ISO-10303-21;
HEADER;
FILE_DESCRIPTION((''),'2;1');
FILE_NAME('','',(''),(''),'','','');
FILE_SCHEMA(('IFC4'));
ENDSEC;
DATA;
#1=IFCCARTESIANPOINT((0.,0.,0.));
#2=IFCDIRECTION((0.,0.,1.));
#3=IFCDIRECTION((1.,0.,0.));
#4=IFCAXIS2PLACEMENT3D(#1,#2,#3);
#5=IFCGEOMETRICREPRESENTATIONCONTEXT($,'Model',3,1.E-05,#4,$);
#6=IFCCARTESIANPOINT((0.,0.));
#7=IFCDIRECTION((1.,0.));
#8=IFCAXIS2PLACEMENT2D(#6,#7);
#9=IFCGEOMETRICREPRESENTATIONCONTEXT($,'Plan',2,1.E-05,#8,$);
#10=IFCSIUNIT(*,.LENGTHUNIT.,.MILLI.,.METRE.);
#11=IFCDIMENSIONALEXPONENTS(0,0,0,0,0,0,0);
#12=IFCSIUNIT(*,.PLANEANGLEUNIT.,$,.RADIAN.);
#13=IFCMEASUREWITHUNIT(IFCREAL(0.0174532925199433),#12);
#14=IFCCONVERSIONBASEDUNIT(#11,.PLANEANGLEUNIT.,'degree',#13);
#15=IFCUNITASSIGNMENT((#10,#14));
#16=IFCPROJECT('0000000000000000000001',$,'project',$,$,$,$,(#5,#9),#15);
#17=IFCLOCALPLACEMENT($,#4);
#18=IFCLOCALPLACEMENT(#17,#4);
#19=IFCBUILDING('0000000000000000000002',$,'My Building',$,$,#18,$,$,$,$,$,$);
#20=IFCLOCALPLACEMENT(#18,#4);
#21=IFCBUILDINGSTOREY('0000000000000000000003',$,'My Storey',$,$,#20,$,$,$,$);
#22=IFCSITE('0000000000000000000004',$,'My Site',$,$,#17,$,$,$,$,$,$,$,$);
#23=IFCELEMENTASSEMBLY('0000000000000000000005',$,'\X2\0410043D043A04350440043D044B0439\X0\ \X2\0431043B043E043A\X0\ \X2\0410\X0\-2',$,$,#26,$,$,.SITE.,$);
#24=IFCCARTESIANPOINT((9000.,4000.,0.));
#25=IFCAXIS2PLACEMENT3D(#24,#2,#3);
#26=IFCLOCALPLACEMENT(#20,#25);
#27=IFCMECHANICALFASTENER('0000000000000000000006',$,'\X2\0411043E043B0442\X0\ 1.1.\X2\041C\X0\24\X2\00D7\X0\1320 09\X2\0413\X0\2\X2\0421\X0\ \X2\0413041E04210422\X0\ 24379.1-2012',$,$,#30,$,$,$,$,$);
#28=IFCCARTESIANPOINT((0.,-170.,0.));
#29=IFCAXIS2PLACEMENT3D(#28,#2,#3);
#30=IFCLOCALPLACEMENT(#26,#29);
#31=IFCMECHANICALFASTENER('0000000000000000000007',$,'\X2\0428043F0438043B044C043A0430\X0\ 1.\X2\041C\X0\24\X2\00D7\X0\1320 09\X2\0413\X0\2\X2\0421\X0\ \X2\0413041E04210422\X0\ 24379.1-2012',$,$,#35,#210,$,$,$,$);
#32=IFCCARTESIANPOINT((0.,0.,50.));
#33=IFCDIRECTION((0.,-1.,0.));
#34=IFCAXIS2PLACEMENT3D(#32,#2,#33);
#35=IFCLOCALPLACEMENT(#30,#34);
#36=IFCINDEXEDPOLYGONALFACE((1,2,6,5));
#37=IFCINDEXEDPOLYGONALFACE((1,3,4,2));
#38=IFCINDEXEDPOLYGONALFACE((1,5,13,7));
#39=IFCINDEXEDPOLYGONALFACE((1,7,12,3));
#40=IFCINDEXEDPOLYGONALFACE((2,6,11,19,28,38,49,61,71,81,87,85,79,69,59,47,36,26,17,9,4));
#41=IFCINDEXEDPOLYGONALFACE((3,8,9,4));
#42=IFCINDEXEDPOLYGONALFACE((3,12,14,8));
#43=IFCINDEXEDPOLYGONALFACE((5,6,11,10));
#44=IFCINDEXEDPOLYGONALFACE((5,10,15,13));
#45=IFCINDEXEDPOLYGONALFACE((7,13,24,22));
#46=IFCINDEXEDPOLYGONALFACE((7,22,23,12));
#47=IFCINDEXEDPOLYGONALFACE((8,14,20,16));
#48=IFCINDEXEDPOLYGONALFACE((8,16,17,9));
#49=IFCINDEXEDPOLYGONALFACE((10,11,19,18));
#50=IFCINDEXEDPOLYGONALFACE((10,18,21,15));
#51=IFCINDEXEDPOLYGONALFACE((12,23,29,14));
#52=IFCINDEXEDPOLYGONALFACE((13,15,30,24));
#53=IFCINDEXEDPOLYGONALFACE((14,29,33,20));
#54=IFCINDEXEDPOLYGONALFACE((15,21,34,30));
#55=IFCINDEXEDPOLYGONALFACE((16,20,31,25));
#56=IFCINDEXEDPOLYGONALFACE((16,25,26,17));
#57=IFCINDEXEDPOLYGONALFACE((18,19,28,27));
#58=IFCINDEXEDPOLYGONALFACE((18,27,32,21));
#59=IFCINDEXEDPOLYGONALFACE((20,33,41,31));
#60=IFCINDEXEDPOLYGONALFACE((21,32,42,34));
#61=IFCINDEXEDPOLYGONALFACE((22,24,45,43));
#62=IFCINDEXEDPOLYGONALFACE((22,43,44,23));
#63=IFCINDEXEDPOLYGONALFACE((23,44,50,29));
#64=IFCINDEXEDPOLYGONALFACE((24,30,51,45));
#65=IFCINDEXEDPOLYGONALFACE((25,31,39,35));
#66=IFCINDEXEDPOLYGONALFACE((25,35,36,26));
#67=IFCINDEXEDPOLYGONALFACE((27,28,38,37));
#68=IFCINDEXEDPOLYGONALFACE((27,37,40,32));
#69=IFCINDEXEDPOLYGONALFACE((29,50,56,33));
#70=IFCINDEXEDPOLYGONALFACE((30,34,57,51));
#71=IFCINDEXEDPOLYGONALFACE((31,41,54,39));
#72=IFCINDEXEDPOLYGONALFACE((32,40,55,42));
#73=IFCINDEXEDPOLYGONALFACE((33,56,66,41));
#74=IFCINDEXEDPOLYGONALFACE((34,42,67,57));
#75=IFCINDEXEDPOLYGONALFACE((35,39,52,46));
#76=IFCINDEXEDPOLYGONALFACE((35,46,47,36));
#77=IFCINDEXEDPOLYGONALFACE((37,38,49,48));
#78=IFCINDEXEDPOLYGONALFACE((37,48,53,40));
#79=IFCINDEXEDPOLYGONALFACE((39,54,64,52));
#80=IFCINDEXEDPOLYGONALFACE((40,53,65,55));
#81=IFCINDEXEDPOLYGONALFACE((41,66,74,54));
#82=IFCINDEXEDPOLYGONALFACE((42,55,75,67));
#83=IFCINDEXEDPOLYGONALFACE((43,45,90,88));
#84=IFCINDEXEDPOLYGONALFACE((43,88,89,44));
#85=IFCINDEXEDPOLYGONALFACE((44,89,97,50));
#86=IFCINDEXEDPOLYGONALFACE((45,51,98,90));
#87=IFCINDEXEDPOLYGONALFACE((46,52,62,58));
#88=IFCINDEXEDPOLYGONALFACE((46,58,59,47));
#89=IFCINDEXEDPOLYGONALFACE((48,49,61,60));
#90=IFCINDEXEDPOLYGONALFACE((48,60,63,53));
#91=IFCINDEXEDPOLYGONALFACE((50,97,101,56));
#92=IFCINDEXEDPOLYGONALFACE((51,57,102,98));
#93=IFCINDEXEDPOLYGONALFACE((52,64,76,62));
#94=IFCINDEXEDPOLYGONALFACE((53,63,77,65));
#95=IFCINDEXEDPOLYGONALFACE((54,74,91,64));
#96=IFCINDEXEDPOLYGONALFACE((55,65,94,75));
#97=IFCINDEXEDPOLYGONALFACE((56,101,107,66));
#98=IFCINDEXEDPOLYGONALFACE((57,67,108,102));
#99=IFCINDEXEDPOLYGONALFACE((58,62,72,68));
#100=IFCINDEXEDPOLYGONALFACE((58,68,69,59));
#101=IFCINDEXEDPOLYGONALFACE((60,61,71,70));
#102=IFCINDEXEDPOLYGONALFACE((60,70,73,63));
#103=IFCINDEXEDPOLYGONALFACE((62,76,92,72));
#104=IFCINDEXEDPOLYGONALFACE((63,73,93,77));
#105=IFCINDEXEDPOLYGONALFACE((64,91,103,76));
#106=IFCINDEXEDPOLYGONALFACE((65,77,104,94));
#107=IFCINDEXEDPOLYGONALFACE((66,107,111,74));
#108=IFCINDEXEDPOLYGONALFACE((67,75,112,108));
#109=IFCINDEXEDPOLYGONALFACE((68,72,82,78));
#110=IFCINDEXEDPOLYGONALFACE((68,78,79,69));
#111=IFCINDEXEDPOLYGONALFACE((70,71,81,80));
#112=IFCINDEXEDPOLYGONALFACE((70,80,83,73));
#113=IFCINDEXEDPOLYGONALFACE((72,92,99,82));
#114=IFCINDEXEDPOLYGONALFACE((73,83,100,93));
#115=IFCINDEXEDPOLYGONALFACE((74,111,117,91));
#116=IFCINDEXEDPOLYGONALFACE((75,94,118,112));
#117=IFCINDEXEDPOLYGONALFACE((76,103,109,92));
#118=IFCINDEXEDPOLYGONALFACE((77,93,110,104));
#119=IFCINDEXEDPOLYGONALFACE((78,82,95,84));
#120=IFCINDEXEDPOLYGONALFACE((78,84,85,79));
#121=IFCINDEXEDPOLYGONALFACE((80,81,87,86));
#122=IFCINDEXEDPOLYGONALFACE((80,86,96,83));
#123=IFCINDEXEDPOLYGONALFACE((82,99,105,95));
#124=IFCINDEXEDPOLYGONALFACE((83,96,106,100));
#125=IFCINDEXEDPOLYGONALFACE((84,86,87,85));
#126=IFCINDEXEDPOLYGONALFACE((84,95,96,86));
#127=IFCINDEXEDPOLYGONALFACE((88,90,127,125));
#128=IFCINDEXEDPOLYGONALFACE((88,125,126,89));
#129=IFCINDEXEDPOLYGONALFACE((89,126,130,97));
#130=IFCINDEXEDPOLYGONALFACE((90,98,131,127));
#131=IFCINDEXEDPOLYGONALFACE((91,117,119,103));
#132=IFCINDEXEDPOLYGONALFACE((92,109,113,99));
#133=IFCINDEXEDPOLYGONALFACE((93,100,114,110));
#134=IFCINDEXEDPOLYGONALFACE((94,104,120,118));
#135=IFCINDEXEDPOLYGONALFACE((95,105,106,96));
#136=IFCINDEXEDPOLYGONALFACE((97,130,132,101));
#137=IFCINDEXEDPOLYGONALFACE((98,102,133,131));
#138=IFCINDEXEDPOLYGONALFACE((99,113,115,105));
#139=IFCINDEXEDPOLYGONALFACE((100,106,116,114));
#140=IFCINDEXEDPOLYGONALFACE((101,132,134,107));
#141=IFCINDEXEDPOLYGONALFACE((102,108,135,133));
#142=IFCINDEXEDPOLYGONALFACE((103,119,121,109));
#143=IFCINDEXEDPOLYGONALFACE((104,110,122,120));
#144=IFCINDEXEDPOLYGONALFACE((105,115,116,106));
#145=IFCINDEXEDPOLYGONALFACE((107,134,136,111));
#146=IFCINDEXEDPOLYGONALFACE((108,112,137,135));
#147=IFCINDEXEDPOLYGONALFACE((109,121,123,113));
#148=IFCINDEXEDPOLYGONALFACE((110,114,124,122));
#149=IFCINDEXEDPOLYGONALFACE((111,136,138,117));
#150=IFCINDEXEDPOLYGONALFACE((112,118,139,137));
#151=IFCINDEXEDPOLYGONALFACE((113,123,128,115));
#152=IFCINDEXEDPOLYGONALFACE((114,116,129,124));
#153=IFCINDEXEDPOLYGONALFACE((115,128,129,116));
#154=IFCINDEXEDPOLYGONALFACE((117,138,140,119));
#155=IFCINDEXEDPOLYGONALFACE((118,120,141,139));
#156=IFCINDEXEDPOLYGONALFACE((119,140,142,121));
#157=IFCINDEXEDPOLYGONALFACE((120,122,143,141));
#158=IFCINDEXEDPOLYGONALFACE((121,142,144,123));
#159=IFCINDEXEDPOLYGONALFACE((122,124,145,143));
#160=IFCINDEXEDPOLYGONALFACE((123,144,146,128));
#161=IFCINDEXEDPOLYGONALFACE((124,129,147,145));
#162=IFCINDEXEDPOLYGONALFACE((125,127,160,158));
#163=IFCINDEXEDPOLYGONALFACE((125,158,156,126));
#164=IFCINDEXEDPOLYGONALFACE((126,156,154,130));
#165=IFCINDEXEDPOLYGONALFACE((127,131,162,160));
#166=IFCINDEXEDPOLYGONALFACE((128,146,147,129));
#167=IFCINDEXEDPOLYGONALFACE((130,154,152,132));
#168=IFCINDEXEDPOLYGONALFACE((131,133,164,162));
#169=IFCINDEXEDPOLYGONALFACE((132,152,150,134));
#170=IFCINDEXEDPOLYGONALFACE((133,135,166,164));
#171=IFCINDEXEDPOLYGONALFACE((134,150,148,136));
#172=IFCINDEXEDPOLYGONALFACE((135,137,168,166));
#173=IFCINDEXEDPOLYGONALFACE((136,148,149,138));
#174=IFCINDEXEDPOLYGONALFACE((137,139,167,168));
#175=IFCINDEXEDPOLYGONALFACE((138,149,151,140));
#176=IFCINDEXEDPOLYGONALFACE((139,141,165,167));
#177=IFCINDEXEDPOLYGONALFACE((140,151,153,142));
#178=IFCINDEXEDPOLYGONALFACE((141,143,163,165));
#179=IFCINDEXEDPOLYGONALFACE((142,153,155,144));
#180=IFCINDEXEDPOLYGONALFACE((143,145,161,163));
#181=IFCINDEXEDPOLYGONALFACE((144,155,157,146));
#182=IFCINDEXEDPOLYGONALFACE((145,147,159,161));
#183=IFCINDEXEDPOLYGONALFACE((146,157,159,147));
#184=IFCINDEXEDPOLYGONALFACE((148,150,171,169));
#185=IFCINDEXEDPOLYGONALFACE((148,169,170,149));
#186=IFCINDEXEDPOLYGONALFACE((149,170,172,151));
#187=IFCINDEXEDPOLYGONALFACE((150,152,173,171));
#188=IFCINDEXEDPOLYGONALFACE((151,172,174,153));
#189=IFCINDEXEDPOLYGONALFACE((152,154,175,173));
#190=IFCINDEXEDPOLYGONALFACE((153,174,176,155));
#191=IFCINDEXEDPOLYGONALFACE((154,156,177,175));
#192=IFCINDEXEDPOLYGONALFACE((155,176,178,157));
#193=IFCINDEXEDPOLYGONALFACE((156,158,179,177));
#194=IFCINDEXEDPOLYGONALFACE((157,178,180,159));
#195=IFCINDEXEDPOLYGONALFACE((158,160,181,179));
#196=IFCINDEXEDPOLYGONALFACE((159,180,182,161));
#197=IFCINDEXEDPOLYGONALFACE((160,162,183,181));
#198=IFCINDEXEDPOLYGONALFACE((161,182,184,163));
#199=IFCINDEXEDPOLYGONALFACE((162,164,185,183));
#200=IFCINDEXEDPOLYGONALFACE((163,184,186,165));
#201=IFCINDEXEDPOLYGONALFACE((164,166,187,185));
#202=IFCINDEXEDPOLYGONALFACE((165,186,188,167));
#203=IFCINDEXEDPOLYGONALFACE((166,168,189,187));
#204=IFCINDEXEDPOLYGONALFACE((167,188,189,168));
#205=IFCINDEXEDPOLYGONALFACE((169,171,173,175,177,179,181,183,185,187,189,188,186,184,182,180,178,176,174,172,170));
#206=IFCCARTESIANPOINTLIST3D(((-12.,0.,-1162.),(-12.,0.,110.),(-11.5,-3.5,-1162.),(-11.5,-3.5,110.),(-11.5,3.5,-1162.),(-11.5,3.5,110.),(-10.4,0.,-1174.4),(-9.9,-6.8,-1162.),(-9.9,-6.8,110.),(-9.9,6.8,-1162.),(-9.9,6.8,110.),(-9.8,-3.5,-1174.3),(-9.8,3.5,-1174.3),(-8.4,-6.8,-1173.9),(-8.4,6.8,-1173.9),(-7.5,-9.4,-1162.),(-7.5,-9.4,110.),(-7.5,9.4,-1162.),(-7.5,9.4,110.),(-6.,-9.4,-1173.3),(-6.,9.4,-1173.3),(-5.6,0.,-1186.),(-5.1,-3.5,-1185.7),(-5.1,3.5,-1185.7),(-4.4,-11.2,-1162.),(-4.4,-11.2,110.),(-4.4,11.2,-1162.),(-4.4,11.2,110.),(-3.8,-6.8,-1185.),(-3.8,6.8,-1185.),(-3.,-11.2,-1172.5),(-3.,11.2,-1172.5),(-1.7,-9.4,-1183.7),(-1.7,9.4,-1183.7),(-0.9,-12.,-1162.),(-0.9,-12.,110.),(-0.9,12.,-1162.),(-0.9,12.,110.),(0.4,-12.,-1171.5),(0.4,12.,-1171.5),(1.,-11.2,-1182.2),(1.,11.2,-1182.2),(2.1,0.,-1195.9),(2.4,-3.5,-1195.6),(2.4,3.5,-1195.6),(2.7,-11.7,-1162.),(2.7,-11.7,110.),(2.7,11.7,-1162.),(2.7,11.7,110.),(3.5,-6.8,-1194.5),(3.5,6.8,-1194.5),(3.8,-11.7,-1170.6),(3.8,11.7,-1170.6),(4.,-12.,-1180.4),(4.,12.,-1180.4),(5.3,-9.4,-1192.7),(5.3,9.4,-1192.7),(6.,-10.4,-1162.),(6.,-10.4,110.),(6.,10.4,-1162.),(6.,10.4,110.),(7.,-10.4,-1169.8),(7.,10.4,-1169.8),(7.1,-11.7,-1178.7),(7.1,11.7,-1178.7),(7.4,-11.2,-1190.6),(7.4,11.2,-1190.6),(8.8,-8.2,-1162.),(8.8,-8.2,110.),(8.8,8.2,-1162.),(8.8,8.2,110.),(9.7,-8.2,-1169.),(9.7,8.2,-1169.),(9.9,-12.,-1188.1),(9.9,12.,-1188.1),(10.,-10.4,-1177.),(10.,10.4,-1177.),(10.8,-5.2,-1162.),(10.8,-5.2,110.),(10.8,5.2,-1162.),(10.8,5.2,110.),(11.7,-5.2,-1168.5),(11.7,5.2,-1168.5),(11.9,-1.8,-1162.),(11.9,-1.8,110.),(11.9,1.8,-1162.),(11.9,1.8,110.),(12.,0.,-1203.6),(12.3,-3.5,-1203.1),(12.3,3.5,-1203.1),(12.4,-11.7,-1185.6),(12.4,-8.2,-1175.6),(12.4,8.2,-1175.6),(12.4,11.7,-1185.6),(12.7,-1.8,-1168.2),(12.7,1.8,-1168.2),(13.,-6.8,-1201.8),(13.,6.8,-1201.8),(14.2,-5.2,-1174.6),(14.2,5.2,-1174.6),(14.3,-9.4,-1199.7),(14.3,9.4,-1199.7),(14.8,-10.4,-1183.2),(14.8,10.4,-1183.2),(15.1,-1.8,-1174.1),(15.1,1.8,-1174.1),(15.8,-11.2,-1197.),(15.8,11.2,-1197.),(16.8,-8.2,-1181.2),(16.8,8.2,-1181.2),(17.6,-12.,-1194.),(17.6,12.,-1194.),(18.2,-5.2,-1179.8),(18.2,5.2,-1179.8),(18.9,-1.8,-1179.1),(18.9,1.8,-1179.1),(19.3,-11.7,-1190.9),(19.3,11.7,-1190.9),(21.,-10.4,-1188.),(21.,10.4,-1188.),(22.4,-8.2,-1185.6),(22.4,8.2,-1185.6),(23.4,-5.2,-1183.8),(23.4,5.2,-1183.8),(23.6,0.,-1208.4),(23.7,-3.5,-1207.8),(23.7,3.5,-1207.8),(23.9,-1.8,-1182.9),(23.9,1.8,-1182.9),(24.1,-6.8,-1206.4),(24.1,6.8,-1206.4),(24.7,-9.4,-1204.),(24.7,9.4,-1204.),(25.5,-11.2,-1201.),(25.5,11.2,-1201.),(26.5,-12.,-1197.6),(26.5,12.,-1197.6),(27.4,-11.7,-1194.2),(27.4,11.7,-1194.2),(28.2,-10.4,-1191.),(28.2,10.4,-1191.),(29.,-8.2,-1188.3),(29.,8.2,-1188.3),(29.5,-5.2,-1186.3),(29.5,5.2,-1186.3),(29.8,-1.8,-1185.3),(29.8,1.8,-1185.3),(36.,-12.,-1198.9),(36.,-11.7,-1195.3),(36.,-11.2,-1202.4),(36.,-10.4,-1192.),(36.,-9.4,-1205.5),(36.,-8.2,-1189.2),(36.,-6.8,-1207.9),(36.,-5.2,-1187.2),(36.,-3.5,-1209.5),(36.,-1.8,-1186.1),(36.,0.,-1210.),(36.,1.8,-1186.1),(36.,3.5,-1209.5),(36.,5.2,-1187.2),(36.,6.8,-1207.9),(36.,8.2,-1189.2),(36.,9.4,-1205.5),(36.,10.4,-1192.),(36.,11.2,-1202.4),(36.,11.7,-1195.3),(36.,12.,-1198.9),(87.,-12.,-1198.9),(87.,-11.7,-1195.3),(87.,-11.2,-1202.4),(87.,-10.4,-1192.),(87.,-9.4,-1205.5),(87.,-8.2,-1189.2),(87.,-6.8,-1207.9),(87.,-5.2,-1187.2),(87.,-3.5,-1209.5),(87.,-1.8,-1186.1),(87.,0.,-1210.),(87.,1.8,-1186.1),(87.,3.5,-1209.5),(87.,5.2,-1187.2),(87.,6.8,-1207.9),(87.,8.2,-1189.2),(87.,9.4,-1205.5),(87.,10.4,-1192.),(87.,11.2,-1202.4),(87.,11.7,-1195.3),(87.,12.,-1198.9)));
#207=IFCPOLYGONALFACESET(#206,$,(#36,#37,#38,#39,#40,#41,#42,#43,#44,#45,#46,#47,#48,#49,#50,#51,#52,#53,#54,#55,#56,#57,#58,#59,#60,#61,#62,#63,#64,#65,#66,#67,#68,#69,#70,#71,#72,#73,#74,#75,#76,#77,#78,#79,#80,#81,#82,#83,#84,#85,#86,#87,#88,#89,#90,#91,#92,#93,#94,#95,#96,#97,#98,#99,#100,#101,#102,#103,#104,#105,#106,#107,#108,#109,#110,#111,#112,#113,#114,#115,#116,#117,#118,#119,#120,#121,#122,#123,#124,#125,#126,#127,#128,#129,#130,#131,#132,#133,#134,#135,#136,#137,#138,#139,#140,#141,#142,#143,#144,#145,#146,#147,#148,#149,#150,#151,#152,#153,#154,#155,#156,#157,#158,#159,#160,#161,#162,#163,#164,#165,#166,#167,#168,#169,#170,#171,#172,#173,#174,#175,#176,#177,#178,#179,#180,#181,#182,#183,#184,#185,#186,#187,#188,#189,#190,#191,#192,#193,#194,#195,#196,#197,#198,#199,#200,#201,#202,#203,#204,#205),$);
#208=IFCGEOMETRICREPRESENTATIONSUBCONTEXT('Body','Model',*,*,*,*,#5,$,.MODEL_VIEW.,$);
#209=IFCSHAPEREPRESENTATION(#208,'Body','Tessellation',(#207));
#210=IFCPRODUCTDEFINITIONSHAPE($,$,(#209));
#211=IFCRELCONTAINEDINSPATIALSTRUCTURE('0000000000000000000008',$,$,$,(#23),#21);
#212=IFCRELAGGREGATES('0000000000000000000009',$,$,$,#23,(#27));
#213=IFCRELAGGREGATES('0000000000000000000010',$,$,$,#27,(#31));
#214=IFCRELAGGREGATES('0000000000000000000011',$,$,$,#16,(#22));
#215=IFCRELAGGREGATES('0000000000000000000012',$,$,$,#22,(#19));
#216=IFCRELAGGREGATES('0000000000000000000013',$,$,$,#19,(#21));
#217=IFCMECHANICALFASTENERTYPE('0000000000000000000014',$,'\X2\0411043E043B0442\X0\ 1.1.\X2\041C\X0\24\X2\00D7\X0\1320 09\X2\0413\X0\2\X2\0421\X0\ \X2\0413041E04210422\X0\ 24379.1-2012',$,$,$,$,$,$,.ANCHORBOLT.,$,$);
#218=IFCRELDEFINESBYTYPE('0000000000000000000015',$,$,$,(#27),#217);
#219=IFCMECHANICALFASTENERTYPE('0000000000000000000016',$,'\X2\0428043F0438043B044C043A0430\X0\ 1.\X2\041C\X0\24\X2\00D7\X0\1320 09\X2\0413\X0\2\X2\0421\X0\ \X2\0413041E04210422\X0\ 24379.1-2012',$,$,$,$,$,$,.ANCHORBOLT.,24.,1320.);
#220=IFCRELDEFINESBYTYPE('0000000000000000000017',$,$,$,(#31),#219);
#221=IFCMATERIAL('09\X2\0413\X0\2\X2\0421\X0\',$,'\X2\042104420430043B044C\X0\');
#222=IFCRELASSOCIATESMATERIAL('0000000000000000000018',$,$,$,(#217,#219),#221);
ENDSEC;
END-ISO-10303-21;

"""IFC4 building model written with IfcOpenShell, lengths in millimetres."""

from ifc_helpers import new_model, entity, si_unit, converted_unit, frame, origin_with_axes, origin_2d_with_axis, place, context, subcontext, project, spatial, source, transform, mapped, material, type_object, type_shapes, element, aggregate, save


model = new_model("IFC4")

# Units and contexts
model_context = context("Model", 3, precision=1e-05, world=origin_with_axes())
plan_context = context("Plan", 2, precision=1e-05, world=origin_2d_with_axis())
body_context = subcontext(model_context, "Body", "Model", "MODEL_VIEW")
ifc_project = project(units=[si_unit("LENGTHUNIT", "METRE", prefix="MILLI"), converted_unit("PLANEANGLEUNIT", "degree", entity("IfcReal", 0.0174532925199433), si_unit("PLANEANGLEUNIT", "RADIAN"), dimensions=[0, 0, 0, 0, 0, 0, 0])], contexts=[model_context, plan_context])

# Site, building, storey
site_placement = place(None, origin_with_axes())
site = spatial("IfcSite", under=ifc_project, at=site_placement, Name="My Site")
building_placement = place(site_placement, origin_with_axes())
building = spatial("IfcBuilding", under=site, at=building_placement, Name="My Building")
storey_placement = place(building_placement, origin_with_axes())
storey = spatial("IfcBuildingStorey", under=building, at=storey_placement, Name="My Storey")

# Element assembly, mechanical fasteners
ifc_material_1 = material(Name="09Г2С", Category="Сталь")
mechanical_fastener_type_1 = type_object("IfcMechanicalFastenerType", Name="Болт 1.1.М24×1320 09Г2С ГОСТ 24379.1-2012", PredefinedType="ANCHORBOLT", material=ifc_material_1)
mechanical_fastener_type_2 = type_object("IfcMechanicalFastenerType", Name="Шпилька 1.М24×1320 09Г2С ГОСТ 24379.1-2012", NominalDiameter=24.0, NominalLength=1320.0, PredefinedType="ANCHORBOLT", material=ifc_material_1)
shared_shape_1 = source(frame((0.0, 0.0, 110.0), z_axis=(0.0, 0.0, 1.0), x_axis=(1.0, 0.0, 0.0)), body_context, "Body", "AdvancedSweptSolid", [
    entity("IfcSweptDiskSolid", entity("IfcIndexedPolyCurve", entity("IfcCartesianPointList3D", [[0.0, 0.0, 0.0], [0.0, 0.0, -1272.0], [10.5, 0.0, -1297.5], [36.0, 0.0, -1308.0], [87.0, 0.0, -1308.0]]), [entity("IfcLineIndex", [1, 2]), entity("IfcArcIndex", [2, 3, 4]), entity("IfcLineIndex", [4, 5])]), 12.0),
])
type_shapes(mechanical_fastener_type_2, [shared_shape_1])
assembly_1_placement = place(storey_placement, frame((9000.0, 4000.0, 0.0), z_axis=(0.0, 0.0, 1.0), x_axis=(1.0, 0.0, 0.0)))
assembly_1 = element("IfcElementAssembly", 1, at=assembly_1_placement, inside=storey, Name="Анкерный блок А-2", AssemblyPlace="SITE")
mechanical_fastener_1_placement = place(assembly_1_placement, frame((0.0, -170.0, 0.0), z_axis=(0.0, 0.0, 1.0), x_axis=(1.0, 0.0, 0.0)))
mechanical_fastener_1 = element("IfcMechanicalFastener", 2, at=mechanical_fastener_1_placement, type_object=mechanical_fastener_type_1, Name="Болт 1.1.М24×1320 09Г2С ГОСТ 24379.1-2012")
mechanical_fastener_2_placement = place(mechanical_fastener_1_placement, frame((0.0, 0.0, 50.0), z_axis=(0.0, 0.0, 1.0), x_axis=(0.0, -1.0, 0.0)))
mechanical_fastener_2 = element("IfcMechanicalFastener", 3, at=mechanical_fastener_2_placement, type_object=mechanical_fastener_type_2, Name="Шпилька 1.М24×1320 09Г2С ГОСТ 24379.1-2012", context=body_context, shape_type="MappedRepresentation", body=[
    mapped(shared_shape_1, transform((0.0, 0.0, 0.0), x_axis=(1.0, 0.0, 0.0), y_axis=(0.0, 1.0, 0.0), z_axis=(0.0, 0.0, 1.0), scale=1.0)),
])
aggregate(assembly_1, [mechanical_fastener_1])

aggregate(mechanical_fastener_1, [mechanical_fastener_2])

save(model, "model.ifc")
